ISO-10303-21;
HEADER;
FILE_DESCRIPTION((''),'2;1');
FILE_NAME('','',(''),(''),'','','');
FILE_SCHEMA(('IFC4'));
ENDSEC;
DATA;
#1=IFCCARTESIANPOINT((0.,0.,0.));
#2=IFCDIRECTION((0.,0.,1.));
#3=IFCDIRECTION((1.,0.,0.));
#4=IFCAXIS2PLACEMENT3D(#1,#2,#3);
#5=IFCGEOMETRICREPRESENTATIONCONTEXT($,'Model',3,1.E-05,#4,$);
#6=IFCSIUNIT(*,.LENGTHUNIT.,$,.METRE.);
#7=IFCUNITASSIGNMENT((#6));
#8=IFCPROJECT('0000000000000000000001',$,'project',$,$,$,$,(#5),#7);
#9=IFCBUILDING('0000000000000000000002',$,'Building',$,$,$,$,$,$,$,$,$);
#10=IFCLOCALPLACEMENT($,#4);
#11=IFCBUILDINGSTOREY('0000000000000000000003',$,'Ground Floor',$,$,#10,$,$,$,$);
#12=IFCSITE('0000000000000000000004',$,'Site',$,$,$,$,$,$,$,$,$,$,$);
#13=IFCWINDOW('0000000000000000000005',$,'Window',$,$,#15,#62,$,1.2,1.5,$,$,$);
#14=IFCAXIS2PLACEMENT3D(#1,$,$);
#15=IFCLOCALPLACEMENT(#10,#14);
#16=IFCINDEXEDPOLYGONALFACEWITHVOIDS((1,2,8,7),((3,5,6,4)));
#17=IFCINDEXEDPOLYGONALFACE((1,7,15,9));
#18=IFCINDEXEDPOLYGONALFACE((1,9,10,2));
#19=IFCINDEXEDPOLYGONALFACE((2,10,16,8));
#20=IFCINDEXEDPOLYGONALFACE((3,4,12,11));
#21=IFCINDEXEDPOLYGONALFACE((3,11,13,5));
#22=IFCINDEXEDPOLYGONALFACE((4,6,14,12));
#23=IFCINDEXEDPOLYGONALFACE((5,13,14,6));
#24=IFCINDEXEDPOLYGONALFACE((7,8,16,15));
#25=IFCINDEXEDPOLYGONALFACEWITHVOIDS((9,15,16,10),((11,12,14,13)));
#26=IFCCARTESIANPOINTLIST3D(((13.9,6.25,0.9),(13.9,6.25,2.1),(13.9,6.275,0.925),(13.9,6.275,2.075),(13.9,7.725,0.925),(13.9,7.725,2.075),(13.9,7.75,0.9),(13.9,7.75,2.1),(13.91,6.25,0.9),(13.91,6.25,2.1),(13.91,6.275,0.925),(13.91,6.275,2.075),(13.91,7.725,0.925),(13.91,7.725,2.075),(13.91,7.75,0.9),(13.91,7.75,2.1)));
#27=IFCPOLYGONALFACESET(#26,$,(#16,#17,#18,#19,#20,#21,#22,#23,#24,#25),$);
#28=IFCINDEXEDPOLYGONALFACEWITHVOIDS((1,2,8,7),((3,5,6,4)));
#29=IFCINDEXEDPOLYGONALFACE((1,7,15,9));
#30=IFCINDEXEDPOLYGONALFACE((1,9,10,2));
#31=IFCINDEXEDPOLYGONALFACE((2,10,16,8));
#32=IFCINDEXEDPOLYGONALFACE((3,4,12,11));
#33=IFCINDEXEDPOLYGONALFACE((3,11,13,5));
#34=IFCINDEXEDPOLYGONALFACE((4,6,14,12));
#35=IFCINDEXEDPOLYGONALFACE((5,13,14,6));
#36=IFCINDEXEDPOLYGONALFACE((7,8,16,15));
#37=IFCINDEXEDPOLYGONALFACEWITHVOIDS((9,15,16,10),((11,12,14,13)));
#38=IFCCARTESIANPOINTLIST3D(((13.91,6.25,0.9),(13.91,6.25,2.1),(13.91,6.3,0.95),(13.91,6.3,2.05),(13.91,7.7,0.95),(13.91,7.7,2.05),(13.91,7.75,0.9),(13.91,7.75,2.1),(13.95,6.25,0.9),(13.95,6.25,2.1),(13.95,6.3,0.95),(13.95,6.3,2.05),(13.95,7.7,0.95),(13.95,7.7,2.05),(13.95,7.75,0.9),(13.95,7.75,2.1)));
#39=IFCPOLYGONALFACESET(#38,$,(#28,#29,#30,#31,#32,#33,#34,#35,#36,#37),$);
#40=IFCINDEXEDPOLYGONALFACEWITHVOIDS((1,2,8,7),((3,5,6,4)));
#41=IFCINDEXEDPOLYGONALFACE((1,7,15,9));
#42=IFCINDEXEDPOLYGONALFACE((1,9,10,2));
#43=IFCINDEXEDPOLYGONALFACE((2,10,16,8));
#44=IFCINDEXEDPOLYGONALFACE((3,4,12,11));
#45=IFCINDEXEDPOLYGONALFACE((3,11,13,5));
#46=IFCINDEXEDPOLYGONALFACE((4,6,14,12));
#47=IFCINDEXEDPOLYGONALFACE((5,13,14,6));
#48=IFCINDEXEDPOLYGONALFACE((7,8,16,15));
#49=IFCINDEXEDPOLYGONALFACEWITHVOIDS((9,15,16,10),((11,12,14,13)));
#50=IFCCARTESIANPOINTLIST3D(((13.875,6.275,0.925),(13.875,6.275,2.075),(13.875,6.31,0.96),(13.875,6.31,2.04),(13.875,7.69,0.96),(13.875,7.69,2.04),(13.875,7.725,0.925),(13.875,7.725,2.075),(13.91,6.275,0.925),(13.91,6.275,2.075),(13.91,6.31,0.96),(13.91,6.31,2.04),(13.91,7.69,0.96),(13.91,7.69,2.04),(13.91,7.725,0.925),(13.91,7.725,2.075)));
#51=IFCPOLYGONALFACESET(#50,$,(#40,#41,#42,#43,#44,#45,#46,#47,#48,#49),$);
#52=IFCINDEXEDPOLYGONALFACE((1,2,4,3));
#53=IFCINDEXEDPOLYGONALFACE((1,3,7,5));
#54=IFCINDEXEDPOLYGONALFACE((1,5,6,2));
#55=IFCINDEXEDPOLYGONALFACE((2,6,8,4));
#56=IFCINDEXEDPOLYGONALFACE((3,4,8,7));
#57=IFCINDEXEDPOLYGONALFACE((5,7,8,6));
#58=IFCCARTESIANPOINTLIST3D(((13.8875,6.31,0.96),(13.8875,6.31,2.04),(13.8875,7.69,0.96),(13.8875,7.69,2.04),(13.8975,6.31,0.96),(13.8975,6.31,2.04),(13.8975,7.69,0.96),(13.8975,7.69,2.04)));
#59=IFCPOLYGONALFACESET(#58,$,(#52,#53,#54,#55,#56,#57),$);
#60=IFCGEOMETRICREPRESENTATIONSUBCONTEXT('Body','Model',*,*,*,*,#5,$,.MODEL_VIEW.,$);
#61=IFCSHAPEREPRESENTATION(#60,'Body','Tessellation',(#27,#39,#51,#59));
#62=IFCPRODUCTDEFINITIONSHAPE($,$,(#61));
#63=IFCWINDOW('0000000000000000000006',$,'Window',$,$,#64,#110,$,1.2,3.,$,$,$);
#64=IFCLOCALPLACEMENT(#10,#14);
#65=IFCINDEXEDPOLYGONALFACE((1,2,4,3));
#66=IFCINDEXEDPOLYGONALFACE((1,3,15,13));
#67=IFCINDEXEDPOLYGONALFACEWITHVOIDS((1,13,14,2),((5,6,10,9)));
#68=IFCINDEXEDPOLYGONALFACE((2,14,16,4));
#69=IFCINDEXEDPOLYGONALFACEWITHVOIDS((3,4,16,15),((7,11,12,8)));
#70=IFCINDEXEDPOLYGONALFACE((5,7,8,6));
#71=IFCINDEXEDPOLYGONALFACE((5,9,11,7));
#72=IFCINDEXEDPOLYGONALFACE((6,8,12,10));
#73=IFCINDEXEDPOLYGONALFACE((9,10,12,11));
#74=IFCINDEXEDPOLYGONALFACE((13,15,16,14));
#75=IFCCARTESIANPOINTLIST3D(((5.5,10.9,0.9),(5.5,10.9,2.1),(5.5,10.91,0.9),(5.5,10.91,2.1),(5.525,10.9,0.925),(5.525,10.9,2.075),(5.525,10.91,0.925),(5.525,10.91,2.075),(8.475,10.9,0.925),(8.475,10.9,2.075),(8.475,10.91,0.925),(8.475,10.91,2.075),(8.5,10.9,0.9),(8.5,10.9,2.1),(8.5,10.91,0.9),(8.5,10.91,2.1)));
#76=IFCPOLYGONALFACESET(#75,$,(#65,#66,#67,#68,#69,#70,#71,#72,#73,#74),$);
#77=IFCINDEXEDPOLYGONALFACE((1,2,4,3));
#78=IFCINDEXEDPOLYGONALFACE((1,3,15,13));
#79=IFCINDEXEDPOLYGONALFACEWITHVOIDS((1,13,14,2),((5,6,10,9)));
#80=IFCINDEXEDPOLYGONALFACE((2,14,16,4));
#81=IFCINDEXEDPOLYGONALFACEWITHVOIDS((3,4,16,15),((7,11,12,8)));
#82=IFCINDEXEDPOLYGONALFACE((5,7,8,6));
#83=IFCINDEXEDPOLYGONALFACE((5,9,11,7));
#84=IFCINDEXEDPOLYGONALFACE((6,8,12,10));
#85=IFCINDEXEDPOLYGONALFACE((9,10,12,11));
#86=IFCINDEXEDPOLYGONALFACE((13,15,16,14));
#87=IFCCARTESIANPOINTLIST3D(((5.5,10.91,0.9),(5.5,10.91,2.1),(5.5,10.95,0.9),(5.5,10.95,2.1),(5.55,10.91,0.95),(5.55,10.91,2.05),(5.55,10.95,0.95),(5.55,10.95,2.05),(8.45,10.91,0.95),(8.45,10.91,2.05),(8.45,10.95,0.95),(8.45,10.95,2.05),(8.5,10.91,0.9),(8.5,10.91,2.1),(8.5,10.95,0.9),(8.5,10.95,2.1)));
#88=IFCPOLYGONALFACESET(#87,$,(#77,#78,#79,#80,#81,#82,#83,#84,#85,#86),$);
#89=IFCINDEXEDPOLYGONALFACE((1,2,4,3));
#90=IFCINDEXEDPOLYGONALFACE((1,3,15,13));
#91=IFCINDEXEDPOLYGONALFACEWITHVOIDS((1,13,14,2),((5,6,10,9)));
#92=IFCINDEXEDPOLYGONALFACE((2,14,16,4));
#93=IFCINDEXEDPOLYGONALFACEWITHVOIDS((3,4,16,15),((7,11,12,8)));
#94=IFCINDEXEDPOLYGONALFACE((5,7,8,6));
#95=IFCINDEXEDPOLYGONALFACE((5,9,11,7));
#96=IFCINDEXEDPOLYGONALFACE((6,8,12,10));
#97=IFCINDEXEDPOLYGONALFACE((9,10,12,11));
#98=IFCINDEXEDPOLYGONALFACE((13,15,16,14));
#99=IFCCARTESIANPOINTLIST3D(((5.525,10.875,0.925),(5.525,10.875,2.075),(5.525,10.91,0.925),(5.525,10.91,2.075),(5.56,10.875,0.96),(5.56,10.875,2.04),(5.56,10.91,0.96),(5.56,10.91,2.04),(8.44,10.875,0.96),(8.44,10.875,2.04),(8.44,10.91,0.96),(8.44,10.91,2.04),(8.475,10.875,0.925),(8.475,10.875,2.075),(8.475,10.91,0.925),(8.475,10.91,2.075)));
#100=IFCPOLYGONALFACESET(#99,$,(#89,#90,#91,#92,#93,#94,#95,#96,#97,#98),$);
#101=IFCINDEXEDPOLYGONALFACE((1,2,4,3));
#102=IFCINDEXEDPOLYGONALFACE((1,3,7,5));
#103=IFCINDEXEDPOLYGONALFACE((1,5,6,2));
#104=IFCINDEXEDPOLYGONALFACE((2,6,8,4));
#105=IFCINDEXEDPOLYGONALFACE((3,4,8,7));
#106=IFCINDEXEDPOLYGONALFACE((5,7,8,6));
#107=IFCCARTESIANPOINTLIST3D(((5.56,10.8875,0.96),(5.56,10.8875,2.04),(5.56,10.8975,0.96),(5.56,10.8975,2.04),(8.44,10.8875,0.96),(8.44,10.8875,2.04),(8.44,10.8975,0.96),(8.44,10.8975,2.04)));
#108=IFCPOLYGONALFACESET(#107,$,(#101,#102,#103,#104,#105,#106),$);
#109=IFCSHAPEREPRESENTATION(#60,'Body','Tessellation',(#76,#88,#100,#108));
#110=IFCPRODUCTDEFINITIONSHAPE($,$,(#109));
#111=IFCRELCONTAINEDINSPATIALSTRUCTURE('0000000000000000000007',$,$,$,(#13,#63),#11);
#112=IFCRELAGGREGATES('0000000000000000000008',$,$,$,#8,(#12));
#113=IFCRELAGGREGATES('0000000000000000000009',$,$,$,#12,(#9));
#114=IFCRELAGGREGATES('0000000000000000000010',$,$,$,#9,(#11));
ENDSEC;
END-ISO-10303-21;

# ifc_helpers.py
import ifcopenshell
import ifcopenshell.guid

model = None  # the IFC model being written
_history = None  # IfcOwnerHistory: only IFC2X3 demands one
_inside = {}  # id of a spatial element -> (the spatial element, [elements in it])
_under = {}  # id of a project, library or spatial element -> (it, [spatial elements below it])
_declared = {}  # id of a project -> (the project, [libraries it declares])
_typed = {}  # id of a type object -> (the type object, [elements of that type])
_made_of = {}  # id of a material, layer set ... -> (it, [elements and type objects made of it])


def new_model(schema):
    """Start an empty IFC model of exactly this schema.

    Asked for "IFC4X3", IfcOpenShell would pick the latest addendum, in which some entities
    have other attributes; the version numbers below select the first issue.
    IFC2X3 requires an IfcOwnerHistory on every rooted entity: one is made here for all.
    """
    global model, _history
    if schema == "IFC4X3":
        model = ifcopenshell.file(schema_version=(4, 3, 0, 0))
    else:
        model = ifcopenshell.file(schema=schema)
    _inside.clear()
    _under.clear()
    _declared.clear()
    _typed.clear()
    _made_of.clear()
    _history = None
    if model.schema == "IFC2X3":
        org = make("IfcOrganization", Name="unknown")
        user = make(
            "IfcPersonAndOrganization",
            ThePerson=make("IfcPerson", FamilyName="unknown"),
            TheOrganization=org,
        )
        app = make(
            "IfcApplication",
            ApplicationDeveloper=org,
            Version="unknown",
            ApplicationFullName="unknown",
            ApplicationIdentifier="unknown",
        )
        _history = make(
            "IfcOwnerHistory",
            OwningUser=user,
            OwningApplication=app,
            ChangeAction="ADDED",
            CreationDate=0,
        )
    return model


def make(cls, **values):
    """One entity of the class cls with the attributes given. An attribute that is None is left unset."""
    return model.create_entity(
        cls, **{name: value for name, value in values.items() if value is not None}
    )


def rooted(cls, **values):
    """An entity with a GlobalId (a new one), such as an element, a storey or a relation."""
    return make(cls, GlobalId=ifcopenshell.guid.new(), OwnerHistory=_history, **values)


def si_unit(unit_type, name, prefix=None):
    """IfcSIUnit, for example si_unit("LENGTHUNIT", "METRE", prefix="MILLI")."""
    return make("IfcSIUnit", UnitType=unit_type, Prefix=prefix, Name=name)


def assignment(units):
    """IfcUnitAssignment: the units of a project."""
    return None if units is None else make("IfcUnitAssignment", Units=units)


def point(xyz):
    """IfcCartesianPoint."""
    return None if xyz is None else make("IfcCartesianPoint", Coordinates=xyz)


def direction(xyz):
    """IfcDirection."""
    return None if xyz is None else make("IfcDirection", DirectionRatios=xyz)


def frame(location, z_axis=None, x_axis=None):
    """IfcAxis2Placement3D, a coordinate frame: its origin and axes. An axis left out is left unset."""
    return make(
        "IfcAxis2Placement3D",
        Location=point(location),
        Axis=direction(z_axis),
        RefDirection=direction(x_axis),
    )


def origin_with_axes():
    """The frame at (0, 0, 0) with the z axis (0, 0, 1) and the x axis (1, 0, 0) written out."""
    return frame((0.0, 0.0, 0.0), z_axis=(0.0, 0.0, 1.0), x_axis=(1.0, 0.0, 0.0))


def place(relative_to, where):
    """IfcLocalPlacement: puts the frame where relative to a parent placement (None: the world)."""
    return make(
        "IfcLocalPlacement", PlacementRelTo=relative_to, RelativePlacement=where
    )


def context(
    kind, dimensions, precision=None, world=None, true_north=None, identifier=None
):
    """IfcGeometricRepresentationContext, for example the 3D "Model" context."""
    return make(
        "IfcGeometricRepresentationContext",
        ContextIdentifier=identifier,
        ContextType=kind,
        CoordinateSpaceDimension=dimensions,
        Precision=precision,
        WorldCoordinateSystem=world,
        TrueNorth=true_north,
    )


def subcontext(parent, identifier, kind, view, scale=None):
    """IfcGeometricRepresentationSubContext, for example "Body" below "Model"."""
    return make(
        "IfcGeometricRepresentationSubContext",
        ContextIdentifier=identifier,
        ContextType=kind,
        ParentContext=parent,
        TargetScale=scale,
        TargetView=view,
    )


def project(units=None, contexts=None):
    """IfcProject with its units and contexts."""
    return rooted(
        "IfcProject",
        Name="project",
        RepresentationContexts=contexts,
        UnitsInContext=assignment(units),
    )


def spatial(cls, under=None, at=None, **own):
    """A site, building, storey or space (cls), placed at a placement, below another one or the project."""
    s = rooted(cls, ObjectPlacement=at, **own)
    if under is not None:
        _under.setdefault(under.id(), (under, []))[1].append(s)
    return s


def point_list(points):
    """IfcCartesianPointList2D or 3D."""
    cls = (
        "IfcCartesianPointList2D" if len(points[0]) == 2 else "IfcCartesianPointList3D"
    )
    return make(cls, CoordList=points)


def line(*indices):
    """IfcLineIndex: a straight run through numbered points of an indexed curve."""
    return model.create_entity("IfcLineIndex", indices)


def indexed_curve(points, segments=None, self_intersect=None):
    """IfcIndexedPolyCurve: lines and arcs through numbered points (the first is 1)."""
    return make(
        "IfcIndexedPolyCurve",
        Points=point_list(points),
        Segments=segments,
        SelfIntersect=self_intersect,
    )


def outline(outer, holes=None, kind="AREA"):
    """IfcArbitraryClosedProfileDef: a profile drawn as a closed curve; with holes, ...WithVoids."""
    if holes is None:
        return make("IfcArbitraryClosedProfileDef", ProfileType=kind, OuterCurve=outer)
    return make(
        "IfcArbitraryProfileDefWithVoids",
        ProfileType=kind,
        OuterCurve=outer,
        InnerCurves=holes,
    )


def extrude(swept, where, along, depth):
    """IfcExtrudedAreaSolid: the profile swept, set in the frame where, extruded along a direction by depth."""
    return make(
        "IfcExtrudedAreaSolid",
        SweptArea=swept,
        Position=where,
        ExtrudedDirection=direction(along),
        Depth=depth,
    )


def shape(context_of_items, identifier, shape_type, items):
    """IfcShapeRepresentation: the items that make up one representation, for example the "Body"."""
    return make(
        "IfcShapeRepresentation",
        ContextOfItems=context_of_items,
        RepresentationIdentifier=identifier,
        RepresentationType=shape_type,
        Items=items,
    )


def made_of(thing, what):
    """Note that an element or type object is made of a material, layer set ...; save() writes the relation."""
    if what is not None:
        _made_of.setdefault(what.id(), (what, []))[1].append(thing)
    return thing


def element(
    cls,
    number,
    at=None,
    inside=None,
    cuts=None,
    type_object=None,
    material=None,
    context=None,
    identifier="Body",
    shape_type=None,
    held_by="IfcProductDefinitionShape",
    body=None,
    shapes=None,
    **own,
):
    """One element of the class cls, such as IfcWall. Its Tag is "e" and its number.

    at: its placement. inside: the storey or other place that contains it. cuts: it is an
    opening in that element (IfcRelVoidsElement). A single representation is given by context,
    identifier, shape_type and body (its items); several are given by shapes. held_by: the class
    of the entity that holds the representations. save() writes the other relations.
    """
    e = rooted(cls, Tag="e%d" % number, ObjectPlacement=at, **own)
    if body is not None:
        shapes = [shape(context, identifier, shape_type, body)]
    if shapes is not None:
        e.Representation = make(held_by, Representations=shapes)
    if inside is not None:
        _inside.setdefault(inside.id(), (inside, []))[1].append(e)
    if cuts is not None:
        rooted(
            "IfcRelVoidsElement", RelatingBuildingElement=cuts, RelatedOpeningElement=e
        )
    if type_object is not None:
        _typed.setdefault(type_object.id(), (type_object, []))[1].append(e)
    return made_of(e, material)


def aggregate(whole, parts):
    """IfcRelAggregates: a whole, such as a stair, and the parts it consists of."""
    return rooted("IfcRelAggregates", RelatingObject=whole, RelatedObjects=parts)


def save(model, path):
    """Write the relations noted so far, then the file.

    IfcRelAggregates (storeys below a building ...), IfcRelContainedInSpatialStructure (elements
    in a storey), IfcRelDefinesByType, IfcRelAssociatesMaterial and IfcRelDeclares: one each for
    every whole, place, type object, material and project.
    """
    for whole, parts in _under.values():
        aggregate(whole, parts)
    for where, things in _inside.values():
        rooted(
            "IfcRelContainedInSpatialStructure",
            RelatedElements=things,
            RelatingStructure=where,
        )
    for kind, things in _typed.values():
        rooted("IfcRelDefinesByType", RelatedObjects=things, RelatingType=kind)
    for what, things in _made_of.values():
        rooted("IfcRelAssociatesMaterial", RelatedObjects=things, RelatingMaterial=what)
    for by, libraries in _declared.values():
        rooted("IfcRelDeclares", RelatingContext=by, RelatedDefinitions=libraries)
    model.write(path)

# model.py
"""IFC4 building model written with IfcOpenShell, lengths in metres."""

from ifc_helpers import new_model, si_unit, frame, origin_with_axes, place, context, subcontext, project, spatial, line, indexed_curve, outline, extrude, element, save


model = new_model("IFC4")

# Units and contexts
model_context = context("Model", 3, precision=1e-05, world=origin_with_axes())
body_context = subcontext(model_context, "Body", "Model", "MODEL_VIEW")
ifc_project = project(units=[si_unit("LENGTHUNIT", "METRE")], contexts=[model_context])

# Site, building, storey
site = spatial("IfcSite", under=ifc_project, Name="Site")
building = spatial("IfcBuilding", under=site, Name="Building")
storey_placement = place(None, origin_with_axes())
storey = spatial("IfcBuildingStorey", under=building, at=storey_placement, Name="Ground Floor")

# Windows
window_1_placement = place(storey_placement, frame((14.0, 6.25, 0.9), z_axis=(0.0, 0.0, 1.0), x_axis=(0.0, 1.0, 0.0)))
element("IfcWindow", 1, at=window_1_placement, inside=storey, Name="Window", OverallHeight=1.2, OverallWidth=1.5, context=body_context, shape_type="SweptSolid", body=[
    extrude(outline(indexed_curve([(0.0, 0.0), (1.5, 0.0), (1.5, 1.2), (0.0, 1.2)], segments=[line(1, 2, 3, 4, 1)]), holes=[indexed_curve([(0.025, 0.025), (1.475, 0.025), (1.475, 1.175), (0.025, 1.175)], segments=[line(1, 2, 3, 4, 1)])]), frame((0.0, 0.09, 0.0), z_axis=(0.0, -1.0, 0.0), x_axis=(1.0, 0.0, 0.0)), (0.0, 0.0, -1.0), 0.01),
    extrude(outline(indexed_curve([(0.0, 0.0), (1.5, 0.0), (1.5, 1.2), (0.0, 1.2)], segments=[line(1, 2, 3, 4, 1)]), holes=[indexed_curve([(0.05, 0.05), (1.45, 0.05), (1.45, 1.15), (0.05, 1.15)], segments=[line(1, 2, 3, 4, 1)])]), frame((0.0, 0.05, 0.0), z_axis=(0.0, -1.0, 0.0), x_axis=(1.0, 0.0, 0.0)), (0.0, 0.0, -1.0), 0.04),
    extrude(outline(indexed_curve([(0.0, 0.0), (1.45, 0.0), (1.45, 1.15), (0.0, 1.15)], segments=[line(1, 2, 3, 4, 1)]), holes=[indexed_curve([(0.035, 0.035), (1.415, 0.035), (1.415, 1.115), (0.035, 1.115)], segments=[line(1, 2, 3, 4, 1)])]), frame((0.025, 0.09, 0.025), z_axis=(0.0, -1.0, 0.0), x_axis=(1.0, 0.0, 0.0)), (0.0, 0.0, -1.0), 0.035),
    extrude(outline(indexed_curve([(0.035, 0.035), (1.415, 0.035), (1.415, 1.115), (0.035, 1.115)], segments=[line(1, 2, 3, 4, 1)])), frame((0.025, 0.1025, 0.025), z_axis=(0.0, -1.0, 0.0), x_axis=(1.0, 0.0, 0.0)), (0.0, 0.0, -1.0), 0.01),
])
window_2_placement = place(storey_placement, frame((8.5, 11.0, 0.9), z_axis=(0.0, 0.0, 1.0), x_axis=(-1.0, 0.0, 0.0)))
element("IfcWindow", 2, at=window_2_placement, inside=storey, Name="Window", OverallHeight=1.2, OverallWidth=3.0, context=body_context, shape_type="SweptSolid", body=[
    extrude(outline(indexed_curve([(0.0, 0.0), (3.0, 0.0), (3.0, 1.2), (0.0, 1.2)], segments=[line(1, 2, 3, 4, 1)]), holes=[indexed_curve([(0.025, 0.025), (2.975, 0.025), (2.975, 1.175), (0.025, 1.175)], segments=[line(1, 2, 3, 4, 1)])]), frame((0.0, 0.09, 0.0), z_axis=(0.0, -1.0, 0.0), x_axis=(1.0, 0.0, 0.0)), (0.0, 0.0, -1.0), 0.01),
    extrude(outline(indexed_curve([(0.0, 0.0), (3.0, 0.0), (3.0, 1.2), (0.0, 1.2)], segments=[line(1, 2, 3, 4, 1)]), holes=[indexed_curve([(0.05, 0.05), (2.95, 0.05), (2.95, 1.15), (0.05, 1.15)], segments=[line(1, 2, 3, 4, 1)])]), frame((0.0, 0.05, 0.0), z_axis=(0.0, -1.0, 0.0), x_axis=(1.0, 0.0, 0.0)), (0.0, 0.0, -1.0), 0.04),
    extrude(outline(indexed_curve([(0.0, 0.0), (2.95, 0.0), (2.95, 1.15), (0.0, 1.15)], segments=[line(1, 2, 3, 4, 1)]), holes=[indexed_curve([(0.035, 0.035), (2.915, 0.035), (2.915, 1.115), (0.035, 1.115)], segments=[line(1, 2, 3, 4, 1)])]), frame((0.025, 0.09, 0.025), z_axis=(0.0, -1.0, 0.0), x_axis=(1.0, 0.0, 0.0)), (0.0, 0.0, -1.0), 0.035),
    extrude(outline(indexed_curve([(0.035, 0.035), (2.915, 0.035), (2.915, 1.115), (0.035, 1.115)], segments=[line(1, 2, 3, 4, 1)])), frame((0.025, 0.1025, 0.025), z_axis=(0.0, -1.0, 0.0), x_axis=(1.0, 0.0, 0.0)), (0.0, 0.0, -1.0), 0.01),
])

save(model, "model.ifc")
